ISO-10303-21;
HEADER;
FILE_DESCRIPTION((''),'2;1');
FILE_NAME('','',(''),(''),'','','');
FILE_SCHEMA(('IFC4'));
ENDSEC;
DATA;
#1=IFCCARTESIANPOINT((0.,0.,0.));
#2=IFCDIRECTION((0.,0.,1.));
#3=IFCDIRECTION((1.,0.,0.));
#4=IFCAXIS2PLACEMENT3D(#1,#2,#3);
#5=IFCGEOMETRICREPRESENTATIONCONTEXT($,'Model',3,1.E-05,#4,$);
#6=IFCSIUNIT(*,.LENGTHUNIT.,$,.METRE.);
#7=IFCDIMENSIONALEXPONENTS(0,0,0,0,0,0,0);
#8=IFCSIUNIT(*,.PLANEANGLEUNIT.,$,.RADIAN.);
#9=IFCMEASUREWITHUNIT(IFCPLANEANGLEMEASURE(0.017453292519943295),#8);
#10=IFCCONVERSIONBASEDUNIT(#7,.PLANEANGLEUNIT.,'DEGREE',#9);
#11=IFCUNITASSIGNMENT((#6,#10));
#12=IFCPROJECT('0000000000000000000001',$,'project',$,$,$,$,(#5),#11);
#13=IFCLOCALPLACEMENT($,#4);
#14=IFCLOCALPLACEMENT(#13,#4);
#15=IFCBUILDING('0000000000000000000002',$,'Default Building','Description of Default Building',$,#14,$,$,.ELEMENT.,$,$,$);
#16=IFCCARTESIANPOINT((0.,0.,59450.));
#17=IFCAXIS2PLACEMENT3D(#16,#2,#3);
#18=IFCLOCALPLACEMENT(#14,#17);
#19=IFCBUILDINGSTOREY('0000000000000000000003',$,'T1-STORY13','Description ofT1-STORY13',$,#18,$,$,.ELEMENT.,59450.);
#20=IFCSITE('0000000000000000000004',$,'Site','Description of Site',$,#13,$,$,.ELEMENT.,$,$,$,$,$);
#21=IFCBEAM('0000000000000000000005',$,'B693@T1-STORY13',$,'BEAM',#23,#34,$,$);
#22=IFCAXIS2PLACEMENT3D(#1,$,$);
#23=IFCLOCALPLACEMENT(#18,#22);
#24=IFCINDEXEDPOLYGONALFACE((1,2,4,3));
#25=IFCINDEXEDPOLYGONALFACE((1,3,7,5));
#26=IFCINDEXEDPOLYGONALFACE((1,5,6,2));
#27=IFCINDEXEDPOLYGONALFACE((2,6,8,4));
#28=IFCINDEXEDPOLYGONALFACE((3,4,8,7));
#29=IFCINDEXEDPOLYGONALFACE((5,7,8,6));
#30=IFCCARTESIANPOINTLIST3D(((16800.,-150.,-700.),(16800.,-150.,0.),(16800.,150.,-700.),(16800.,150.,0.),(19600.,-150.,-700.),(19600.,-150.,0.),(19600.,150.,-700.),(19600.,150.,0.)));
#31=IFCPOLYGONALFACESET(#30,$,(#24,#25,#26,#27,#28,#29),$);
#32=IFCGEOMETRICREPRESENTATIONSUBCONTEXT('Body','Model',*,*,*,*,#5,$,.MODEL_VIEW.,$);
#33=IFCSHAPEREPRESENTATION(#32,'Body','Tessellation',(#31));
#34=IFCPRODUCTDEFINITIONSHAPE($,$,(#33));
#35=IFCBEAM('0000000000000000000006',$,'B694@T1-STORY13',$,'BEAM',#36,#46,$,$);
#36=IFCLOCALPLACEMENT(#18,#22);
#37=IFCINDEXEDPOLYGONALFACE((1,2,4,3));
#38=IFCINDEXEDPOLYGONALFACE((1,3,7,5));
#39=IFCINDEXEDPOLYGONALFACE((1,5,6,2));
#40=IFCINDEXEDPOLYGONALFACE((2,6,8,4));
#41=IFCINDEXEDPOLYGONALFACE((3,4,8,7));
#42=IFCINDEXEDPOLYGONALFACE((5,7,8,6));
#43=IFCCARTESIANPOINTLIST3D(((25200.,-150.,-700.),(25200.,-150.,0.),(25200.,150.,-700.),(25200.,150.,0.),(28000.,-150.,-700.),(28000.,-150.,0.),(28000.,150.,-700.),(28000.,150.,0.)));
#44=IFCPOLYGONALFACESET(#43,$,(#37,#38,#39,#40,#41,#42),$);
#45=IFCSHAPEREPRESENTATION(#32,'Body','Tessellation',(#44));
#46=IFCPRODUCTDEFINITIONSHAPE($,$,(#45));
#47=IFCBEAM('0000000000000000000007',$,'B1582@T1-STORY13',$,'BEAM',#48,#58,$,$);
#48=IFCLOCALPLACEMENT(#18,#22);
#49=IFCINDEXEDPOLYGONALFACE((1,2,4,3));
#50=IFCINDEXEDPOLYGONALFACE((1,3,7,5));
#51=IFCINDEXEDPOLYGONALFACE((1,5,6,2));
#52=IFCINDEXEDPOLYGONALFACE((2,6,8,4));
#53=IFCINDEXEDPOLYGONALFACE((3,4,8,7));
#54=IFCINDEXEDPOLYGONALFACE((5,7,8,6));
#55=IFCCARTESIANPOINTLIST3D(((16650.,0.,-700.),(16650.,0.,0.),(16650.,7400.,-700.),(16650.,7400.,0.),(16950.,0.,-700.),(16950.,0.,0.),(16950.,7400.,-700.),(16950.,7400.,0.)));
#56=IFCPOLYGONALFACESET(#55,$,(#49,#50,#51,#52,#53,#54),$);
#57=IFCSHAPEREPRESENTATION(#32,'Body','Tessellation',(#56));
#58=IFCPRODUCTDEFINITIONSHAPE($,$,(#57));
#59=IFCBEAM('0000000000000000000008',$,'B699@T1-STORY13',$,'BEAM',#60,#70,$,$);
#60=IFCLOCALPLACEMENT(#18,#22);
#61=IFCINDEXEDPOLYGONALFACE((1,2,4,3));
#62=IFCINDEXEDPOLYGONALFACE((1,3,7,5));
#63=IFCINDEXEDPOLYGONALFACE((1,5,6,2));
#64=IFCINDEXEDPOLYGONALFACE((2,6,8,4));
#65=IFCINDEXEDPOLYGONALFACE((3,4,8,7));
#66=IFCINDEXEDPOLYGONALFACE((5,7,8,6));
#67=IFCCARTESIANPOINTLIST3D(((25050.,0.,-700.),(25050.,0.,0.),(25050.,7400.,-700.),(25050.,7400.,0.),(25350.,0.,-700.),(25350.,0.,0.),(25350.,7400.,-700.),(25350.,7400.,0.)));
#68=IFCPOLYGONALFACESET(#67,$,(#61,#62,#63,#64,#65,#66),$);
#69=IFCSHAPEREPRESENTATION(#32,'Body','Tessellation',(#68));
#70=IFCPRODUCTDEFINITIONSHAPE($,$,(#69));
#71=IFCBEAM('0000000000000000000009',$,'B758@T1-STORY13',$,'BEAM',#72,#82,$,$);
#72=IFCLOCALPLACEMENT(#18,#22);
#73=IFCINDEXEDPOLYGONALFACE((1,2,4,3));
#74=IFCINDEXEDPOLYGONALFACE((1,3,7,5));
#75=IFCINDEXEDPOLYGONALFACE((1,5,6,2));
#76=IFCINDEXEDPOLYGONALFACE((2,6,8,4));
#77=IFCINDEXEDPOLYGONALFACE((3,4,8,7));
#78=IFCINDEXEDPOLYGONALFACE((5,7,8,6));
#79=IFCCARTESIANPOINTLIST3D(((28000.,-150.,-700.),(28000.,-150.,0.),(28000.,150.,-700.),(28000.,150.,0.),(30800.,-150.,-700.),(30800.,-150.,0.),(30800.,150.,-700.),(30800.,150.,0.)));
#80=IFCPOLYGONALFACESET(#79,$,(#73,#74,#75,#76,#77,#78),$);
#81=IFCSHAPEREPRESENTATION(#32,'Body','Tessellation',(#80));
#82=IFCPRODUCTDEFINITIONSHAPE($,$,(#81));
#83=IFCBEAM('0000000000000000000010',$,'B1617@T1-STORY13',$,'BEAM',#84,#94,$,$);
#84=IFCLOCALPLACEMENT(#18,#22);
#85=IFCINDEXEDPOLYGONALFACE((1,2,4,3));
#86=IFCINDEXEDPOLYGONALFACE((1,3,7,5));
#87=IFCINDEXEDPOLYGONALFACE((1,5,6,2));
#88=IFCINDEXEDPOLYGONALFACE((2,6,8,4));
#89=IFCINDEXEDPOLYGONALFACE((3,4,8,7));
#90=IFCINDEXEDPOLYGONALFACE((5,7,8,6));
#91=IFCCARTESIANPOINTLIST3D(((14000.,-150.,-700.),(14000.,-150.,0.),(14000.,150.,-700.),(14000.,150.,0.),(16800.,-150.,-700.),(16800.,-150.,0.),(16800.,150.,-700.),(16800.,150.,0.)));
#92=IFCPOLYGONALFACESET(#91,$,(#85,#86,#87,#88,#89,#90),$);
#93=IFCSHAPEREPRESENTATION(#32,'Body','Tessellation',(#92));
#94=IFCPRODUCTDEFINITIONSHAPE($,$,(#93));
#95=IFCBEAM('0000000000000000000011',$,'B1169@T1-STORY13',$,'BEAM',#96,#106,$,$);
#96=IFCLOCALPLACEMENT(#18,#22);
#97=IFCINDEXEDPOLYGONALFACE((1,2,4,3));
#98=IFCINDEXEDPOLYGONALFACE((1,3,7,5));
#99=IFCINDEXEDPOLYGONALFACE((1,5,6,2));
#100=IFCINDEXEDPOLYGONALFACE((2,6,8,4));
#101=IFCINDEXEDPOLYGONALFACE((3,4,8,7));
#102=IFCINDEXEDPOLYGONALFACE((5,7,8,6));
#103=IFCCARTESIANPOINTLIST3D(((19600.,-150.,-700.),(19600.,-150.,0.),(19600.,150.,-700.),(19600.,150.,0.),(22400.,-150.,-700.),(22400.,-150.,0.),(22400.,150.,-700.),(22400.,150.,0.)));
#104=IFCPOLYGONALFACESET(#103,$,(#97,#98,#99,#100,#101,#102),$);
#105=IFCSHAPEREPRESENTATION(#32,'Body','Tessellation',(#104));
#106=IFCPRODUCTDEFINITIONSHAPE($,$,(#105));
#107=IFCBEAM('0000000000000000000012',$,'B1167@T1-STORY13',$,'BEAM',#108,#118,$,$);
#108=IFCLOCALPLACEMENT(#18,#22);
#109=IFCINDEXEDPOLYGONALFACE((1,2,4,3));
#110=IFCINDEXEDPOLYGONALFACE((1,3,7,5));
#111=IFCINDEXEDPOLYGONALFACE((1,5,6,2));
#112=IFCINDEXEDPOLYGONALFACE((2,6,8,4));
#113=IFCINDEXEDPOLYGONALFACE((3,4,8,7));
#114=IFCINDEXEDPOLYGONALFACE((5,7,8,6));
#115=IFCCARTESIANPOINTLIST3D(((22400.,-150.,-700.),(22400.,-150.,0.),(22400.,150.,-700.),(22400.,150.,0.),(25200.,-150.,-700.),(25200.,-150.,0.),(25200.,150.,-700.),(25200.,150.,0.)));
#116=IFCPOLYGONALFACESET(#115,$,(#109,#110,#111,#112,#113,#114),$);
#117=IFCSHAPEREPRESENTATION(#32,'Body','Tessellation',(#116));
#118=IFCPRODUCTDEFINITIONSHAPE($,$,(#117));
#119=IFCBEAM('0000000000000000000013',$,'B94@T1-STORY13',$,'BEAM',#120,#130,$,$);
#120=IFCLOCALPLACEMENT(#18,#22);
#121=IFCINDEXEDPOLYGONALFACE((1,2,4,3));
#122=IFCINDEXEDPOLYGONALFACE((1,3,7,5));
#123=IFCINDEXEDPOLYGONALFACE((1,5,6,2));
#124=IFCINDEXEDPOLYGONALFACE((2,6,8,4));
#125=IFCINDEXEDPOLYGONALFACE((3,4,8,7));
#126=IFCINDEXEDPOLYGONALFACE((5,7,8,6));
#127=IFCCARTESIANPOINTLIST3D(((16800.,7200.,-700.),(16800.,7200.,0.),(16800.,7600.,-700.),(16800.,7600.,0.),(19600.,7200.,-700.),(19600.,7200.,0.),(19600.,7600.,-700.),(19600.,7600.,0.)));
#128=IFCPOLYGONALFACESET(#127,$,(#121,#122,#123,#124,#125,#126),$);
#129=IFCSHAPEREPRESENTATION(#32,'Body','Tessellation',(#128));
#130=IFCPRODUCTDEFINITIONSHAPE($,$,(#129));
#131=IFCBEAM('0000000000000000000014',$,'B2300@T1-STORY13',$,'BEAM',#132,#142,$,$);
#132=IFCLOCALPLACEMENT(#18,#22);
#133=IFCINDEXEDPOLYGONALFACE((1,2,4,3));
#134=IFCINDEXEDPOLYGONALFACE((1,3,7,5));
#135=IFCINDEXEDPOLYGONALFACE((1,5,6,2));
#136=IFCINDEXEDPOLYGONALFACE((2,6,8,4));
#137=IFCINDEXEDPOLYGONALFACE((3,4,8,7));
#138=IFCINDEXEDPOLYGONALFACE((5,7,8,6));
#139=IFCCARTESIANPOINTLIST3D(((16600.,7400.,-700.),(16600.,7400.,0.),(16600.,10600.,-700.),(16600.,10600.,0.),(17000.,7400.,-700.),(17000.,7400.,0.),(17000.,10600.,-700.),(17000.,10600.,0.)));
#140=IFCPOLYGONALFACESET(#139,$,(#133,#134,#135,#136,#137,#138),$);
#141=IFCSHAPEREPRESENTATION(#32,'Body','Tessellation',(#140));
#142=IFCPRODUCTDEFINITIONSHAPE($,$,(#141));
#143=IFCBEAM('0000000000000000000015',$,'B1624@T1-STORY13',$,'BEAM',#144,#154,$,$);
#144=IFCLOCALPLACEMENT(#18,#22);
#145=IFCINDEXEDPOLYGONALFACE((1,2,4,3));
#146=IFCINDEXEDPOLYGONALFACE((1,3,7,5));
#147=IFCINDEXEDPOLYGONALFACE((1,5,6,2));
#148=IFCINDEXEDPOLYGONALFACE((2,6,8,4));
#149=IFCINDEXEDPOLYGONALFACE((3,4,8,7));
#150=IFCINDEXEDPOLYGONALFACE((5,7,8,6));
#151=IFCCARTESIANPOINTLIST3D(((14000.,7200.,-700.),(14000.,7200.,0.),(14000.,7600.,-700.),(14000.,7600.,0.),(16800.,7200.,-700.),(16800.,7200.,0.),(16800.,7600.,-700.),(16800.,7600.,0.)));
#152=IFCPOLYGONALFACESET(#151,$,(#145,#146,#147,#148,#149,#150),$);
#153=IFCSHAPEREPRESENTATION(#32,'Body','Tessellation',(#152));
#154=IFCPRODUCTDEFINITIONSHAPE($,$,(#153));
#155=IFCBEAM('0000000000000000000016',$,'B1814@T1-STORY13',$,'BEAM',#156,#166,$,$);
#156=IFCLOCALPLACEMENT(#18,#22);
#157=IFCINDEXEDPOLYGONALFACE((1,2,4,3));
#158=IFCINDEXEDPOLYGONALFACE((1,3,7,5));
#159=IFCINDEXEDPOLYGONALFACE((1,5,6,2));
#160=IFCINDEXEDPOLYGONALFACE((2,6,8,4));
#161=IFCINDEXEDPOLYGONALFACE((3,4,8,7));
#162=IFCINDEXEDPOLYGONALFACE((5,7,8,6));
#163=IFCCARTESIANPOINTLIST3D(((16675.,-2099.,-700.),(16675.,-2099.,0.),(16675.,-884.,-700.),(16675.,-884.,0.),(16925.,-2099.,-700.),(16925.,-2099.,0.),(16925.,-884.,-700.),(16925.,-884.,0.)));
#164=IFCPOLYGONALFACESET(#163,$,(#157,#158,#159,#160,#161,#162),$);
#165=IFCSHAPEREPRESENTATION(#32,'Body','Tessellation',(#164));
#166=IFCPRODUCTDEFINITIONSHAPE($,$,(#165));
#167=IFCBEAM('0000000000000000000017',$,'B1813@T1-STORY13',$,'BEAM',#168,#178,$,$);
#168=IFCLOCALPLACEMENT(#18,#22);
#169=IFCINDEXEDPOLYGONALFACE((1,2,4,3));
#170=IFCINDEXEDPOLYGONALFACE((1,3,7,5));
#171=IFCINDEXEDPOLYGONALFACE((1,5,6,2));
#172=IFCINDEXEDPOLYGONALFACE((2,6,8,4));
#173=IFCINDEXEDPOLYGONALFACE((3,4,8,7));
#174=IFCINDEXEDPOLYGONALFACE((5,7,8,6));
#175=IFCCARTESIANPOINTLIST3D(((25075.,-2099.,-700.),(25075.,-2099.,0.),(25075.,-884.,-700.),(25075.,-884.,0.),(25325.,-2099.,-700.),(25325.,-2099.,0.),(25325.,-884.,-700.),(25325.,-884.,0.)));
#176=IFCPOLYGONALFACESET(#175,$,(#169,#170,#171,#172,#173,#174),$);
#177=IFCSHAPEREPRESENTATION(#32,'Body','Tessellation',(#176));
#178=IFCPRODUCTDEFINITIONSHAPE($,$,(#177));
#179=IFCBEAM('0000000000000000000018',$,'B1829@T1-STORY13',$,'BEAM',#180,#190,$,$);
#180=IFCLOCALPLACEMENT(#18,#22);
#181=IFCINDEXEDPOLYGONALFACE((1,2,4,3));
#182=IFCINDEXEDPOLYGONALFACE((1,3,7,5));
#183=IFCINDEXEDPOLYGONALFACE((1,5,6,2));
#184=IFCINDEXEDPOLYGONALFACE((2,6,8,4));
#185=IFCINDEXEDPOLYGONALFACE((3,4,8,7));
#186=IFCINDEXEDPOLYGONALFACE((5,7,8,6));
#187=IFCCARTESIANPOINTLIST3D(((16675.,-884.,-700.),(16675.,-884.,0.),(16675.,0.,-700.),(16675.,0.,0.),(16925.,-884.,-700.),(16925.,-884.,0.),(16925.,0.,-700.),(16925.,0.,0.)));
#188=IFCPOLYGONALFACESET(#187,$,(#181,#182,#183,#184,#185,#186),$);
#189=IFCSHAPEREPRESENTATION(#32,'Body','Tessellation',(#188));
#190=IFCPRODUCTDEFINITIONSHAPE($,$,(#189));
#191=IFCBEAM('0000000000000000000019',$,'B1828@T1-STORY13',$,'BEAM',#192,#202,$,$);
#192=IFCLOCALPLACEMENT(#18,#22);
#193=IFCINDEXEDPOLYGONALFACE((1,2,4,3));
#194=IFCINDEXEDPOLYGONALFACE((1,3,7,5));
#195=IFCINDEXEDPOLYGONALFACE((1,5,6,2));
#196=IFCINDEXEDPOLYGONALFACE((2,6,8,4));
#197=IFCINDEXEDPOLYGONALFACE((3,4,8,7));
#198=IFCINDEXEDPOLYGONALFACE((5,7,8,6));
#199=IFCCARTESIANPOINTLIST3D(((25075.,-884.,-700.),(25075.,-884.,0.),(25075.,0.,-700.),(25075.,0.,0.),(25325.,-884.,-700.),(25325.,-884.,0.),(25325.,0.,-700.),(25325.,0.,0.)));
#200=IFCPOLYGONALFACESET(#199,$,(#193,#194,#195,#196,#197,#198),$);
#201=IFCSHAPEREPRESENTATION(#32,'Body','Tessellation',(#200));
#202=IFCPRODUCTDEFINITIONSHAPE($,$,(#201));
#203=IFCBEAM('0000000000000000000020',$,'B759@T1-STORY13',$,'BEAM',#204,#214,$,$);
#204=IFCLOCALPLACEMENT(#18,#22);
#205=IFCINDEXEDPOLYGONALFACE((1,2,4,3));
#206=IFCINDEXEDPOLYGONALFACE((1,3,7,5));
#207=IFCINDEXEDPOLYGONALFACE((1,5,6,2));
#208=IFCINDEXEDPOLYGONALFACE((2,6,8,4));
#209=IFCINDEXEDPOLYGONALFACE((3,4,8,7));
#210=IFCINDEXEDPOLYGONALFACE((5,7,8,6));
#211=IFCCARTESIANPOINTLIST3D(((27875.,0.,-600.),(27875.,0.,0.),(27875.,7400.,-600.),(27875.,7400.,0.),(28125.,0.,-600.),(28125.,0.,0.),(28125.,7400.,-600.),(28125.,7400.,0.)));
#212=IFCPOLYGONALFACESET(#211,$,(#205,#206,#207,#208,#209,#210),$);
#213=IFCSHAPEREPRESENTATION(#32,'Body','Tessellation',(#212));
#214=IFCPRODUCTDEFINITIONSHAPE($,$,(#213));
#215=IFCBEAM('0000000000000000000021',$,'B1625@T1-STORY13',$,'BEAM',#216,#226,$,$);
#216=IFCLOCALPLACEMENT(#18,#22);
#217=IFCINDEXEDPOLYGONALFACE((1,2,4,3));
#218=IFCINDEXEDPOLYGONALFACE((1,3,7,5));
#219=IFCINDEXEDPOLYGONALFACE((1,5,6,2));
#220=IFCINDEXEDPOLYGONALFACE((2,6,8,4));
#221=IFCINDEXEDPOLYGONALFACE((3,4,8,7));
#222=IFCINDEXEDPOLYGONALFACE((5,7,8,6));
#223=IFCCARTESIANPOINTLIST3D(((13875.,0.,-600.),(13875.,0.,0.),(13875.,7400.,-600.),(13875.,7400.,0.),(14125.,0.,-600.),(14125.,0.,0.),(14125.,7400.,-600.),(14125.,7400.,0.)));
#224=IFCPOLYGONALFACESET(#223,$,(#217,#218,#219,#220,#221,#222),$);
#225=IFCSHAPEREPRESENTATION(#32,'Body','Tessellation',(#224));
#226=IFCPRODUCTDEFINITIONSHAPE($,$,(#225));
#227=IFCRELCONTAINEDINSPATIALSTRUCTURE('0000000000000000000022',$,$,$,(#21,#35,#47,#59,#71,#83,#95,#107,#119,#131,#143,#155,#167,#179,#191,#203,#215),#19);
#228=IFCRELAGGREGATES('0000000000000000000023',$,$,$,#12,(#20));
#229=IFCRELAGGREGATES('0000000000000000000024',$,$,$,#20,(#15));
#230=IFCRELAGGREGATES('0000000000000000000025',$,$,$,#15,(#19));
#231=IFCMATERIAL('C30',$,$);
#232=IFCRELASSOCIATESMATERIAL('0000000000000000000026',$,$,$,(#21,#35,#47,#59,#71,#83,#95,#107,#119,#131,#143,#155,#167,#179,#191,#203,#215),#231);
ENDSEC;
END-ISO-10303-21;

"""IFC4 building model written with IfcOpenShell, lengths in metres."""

from ifc_helpers import new_model, entity, si_unit, converted_unit, frame, origin_with_axes, place, context, subcontext, project, spatial, rectangle, extrude, material, element, save


model = new_model("IFC4")

# Units and contexts
model_context = context("Model", 3, precision=1e-05, world=origin_with_axes())
body_context = subcontext(model_context, "Body", "Model", "MODEL_VIEW")
ifc_project = project(units=[si_unit("LENGTHUNIT", "METRE"), converted_unit("PLANEANGLEUNIT", "DEGREE", entity("IfcPlaneAngleMeasure", 0.017453292519943295), si_unit("PLANEANGLEUNIT", "RADIAN"), dimensions=[0, 0, 0, 0, 0, 0, 0])], contexts=[model_context])

# Site, building, storey
site_placement = place(None, origin_with_axes())
site = spatial("IfcSite", under=ifc_project, at=site_placement, Name="Site", Description="Description of Site", CompositionType="ELEMENT")
building_placement = place(site_placement, origin_with_axes())
building = spatial("IfcBuilding", under=site, at=building_placement, Name="Default Building", Description="Description of Default Building", CompositionType="ELEMENT")
storey_placement = place(building_placement, frame((0.0, 0.0, 59450.0), z_axis=(0.0, 0.0, 1.0), x_axis=(1.0, 0.0, 0.0)))
storey = spatial("IfcBuildingStorey", under=building, at=storey_placement, Name="T1-STORY13", Description="Description ofT1-STORY13", CompositionType="ELEMENT", Elevation=59450.0)

# Beams
ifc_material_1 = material(Name="C30")
for number, where, z_axis, x_axis, name in (
    (1, (16800.0, 0.0, -350.0), (1.0, 0.0, 0.0), (0.0, 1.0, 0.0), "B693@T1-STORY13"),
    (2, (25200.0, 0.0, -350.0), (1.0, 0.0, 0.0), (0.0, 1.0, 0.0), "B694@T1-STORY13"),
):
    element("IfcBeam", number, at=place(storey_placement, frame(where, z_axis=z_axis, x_axis=x_axis)), inside=storey, material=ifc_material_1, Name=name, ObjectType="BEAM", context=body_context, shape_type="SweptSolid", body=[
        extrude(rectangle(XDim=300.0, YDim=700.0), origin_with_axes(), (0.0, 0.0, 1.0), 2800.0),
    ])
for number, where, z_axis, x_axis, name in (
    (3, (16800.0, 0.0, -350.0), (0.0, 1.0, 0.0), (-1.0, 0.0, 0.0), "B1582@T1-STORY13"),
    (4, (25200.0, 0.0, -350.0), (0.0, 1.0, 0.0), (-1.0, 0.0, 0.0), "B699@T1-STORY13"),
):
    element("IfcBeam", number, at=place(storey_placement, frame(where, z_axis=z_axis, x_axis=x_axis)), inside=storey, material=ifc_material_1, Name=name, ObjectType="BEAM", context=body_context, shape_type="SweptSolid", body=[
        extrude(rectangle(XDim=300.0, YDim=700.0), origin_with_axes(), (0.0, 0.0, 1.0), 7400.0),
    ])
for number, where, z_axis, x_axis, name in (
    (5, (28000.0, 0.0, -350.0), (1.0, 0.0, 0.0), (0.0, 1.0, 0.0), "B758@T1-STORY13"),
    (6, (14000.0, 0.0, -350.0), (1.0, 0.0, 0.0), (0.0, 1.0, 0.0), "B1617@T1-STORY13"),
    (7, (19600.0, 0.0, -350.0), (1.0, 0.0, 0.0), (0.0, 1.0, 0.0), "B1169@T1-STORY13"),
    (8, (22400.0, 0.0, -350.0), (1.0, 0.0, 0.0), (0.0, 1.0, 0.0), "B1167@T1-STORY13"),
):
    element("IfcBeam", number, at=place(storey_placement, frame(where, z_axis=z_axis, x_axis=x_axis)), inside=storey, material=ifc_material_1, Name=name, ObjectType="BEAM", context=body_context, shape_type="SweptSolid", body=[
        extrude(rectangle(XDim=300.0, YDim=700.0), origin_with_axes(), (0.0, 0.0, 1.0), 2800.0),
    ])
beam_1_placement = place(storey_placement, frame((16800.0, 7400.0, -350.0), z_axis=(1.0, 0.0, 0.0), x_axis=(0.0, 1.0, 0.0)))
element("IfcBeam", 9, at=beam_1_placement, inside=storey, material=ifc_material_1, Name="B94@T1-STORY13", ObjectType="BEAM", context=body_context, shape_type="SweptSolid", body=[
    extrude(rectangle(XDim=400.0, YDim=700.0), origin_with_axes(), (0.0, 0.0, 1.0), 2800.0),
])
beam_2_placement = place(storey_placement, frame((16800.0, 7400.0, -350.0), z_axis=(0.0, 1.0, 0.0), x_axis=(-1.0, 0.0, 0.0)))
element("IfcBeam", 10, at=beam_2_placement, inside=storey, material=ifc_material_1, Name="B2300@T1-STORY13", ObjectType="BEAM", context=body_context, shape_type="SweptSolid", body=[
    extrude(rectangle(XDim=400.0, YDim=700.0), origin_with_axes(), (0.0, 0.0, 1.0), 3200.0),
])
beam_3_placement = place(storey_placement, frame((14000.0, 7400.0, -350.0), z_axis=(1.0, 0.0, 0.0), x_axis=(0.0, 1.0, 0.0)))
element("IfcBeam", 11, at=beam_3_placement, inside=storey, material=ifc_material_1, Name="B1624@T1-STORY13", ObjectType="BEAM", context=body_context, shape_type="SweptSolid", body=[
    extrude(rectangle(XDim=400.0, YDim=700.0), origin_with_axes(), (0.0, 0.0, 1.0), 2800.0),
])
for number, where, z_axis, x_axis, name in (
    (12, (16800.0, -2099.0, -350.0), (0.0, 1.0, 0.0), (-1.0, 0.0, 0.0), "B1814@T1-STORY13"),
    (13, (25200.0, -2099.0, -350.0), (0.0, 1.0, 0.0), (-1.0, 0.0, 0.0), "B1813@T1-STORY13"),
):
    element("IfcBeam", number, at=place(storey_placement, frame(where, z_axis=z_axis, x_axis=x_axis)), inside=storey, material=ifc_material_1, Name=name, ObjectType="BEAM", context=body_context, shape_type="SweptSolid", body=[
        extrude(rectangle(XDim=250.0, YDim=700.0), origin_with_axes(), (0.0, 0.0, 1.0), 1215.0),
    ])
for number, where, z_axis, x_axis, name in (
    (14, (16800.0, -884.0, -350.0), (0.0, 1.0, 0.0), (-1.0, 0.0, 0.0), "B1829@T1-STORY13"),
    (15, (25200.0, -884.0, -350.0), (0.0, 1.0, 0.0), (-1.0, 0.0, 0.0), "B1828@T1-STORY13"),
):
    element("IfcBeam", number, at=place(storey_placement, frame(where, z_axis=z_axis, x_axis=x_axis)), inside=storey, material=ifc_material_1, Name=name, ObjectType="BEAM", context=body_context, shape_type="SweptSolid", body=[
        extrude(rectangle(XDim=250.0, YDim=700.0), origin_with_axes(), (0.0, 0.0, 1.0), 884.0),
    ])
for number, where, z_axis, x_axis, name in (
    (16, (28000.0, 0.0, -300.0), (0.0, 1.0, 0.0), (-1.0, 0.0, 0.0), "B759@T1-STORY13"),
    (17, (14000.0, 0.0, -300.0), (0.0, 1.0, 0.0), (-1.0, 0.0, 0.0), "B1625@T1-STORY13"),
):
    element("IfcBeam", number, at=place(storey_placement, frame(where, z_axis=z_axis, x_axis=x_axis)), inside=storey, material=ifc_material_1, Name=name, ObjectType="BEAM", context=body_context, shape_type="SweptSolid", body=[
        extrude(rectangle(XDim=250.0, YDim=600.0), origin_with_axes(), (0.0, 0.0, 1.0), 7400.0),
    ])

save(model, "model.ifc")
